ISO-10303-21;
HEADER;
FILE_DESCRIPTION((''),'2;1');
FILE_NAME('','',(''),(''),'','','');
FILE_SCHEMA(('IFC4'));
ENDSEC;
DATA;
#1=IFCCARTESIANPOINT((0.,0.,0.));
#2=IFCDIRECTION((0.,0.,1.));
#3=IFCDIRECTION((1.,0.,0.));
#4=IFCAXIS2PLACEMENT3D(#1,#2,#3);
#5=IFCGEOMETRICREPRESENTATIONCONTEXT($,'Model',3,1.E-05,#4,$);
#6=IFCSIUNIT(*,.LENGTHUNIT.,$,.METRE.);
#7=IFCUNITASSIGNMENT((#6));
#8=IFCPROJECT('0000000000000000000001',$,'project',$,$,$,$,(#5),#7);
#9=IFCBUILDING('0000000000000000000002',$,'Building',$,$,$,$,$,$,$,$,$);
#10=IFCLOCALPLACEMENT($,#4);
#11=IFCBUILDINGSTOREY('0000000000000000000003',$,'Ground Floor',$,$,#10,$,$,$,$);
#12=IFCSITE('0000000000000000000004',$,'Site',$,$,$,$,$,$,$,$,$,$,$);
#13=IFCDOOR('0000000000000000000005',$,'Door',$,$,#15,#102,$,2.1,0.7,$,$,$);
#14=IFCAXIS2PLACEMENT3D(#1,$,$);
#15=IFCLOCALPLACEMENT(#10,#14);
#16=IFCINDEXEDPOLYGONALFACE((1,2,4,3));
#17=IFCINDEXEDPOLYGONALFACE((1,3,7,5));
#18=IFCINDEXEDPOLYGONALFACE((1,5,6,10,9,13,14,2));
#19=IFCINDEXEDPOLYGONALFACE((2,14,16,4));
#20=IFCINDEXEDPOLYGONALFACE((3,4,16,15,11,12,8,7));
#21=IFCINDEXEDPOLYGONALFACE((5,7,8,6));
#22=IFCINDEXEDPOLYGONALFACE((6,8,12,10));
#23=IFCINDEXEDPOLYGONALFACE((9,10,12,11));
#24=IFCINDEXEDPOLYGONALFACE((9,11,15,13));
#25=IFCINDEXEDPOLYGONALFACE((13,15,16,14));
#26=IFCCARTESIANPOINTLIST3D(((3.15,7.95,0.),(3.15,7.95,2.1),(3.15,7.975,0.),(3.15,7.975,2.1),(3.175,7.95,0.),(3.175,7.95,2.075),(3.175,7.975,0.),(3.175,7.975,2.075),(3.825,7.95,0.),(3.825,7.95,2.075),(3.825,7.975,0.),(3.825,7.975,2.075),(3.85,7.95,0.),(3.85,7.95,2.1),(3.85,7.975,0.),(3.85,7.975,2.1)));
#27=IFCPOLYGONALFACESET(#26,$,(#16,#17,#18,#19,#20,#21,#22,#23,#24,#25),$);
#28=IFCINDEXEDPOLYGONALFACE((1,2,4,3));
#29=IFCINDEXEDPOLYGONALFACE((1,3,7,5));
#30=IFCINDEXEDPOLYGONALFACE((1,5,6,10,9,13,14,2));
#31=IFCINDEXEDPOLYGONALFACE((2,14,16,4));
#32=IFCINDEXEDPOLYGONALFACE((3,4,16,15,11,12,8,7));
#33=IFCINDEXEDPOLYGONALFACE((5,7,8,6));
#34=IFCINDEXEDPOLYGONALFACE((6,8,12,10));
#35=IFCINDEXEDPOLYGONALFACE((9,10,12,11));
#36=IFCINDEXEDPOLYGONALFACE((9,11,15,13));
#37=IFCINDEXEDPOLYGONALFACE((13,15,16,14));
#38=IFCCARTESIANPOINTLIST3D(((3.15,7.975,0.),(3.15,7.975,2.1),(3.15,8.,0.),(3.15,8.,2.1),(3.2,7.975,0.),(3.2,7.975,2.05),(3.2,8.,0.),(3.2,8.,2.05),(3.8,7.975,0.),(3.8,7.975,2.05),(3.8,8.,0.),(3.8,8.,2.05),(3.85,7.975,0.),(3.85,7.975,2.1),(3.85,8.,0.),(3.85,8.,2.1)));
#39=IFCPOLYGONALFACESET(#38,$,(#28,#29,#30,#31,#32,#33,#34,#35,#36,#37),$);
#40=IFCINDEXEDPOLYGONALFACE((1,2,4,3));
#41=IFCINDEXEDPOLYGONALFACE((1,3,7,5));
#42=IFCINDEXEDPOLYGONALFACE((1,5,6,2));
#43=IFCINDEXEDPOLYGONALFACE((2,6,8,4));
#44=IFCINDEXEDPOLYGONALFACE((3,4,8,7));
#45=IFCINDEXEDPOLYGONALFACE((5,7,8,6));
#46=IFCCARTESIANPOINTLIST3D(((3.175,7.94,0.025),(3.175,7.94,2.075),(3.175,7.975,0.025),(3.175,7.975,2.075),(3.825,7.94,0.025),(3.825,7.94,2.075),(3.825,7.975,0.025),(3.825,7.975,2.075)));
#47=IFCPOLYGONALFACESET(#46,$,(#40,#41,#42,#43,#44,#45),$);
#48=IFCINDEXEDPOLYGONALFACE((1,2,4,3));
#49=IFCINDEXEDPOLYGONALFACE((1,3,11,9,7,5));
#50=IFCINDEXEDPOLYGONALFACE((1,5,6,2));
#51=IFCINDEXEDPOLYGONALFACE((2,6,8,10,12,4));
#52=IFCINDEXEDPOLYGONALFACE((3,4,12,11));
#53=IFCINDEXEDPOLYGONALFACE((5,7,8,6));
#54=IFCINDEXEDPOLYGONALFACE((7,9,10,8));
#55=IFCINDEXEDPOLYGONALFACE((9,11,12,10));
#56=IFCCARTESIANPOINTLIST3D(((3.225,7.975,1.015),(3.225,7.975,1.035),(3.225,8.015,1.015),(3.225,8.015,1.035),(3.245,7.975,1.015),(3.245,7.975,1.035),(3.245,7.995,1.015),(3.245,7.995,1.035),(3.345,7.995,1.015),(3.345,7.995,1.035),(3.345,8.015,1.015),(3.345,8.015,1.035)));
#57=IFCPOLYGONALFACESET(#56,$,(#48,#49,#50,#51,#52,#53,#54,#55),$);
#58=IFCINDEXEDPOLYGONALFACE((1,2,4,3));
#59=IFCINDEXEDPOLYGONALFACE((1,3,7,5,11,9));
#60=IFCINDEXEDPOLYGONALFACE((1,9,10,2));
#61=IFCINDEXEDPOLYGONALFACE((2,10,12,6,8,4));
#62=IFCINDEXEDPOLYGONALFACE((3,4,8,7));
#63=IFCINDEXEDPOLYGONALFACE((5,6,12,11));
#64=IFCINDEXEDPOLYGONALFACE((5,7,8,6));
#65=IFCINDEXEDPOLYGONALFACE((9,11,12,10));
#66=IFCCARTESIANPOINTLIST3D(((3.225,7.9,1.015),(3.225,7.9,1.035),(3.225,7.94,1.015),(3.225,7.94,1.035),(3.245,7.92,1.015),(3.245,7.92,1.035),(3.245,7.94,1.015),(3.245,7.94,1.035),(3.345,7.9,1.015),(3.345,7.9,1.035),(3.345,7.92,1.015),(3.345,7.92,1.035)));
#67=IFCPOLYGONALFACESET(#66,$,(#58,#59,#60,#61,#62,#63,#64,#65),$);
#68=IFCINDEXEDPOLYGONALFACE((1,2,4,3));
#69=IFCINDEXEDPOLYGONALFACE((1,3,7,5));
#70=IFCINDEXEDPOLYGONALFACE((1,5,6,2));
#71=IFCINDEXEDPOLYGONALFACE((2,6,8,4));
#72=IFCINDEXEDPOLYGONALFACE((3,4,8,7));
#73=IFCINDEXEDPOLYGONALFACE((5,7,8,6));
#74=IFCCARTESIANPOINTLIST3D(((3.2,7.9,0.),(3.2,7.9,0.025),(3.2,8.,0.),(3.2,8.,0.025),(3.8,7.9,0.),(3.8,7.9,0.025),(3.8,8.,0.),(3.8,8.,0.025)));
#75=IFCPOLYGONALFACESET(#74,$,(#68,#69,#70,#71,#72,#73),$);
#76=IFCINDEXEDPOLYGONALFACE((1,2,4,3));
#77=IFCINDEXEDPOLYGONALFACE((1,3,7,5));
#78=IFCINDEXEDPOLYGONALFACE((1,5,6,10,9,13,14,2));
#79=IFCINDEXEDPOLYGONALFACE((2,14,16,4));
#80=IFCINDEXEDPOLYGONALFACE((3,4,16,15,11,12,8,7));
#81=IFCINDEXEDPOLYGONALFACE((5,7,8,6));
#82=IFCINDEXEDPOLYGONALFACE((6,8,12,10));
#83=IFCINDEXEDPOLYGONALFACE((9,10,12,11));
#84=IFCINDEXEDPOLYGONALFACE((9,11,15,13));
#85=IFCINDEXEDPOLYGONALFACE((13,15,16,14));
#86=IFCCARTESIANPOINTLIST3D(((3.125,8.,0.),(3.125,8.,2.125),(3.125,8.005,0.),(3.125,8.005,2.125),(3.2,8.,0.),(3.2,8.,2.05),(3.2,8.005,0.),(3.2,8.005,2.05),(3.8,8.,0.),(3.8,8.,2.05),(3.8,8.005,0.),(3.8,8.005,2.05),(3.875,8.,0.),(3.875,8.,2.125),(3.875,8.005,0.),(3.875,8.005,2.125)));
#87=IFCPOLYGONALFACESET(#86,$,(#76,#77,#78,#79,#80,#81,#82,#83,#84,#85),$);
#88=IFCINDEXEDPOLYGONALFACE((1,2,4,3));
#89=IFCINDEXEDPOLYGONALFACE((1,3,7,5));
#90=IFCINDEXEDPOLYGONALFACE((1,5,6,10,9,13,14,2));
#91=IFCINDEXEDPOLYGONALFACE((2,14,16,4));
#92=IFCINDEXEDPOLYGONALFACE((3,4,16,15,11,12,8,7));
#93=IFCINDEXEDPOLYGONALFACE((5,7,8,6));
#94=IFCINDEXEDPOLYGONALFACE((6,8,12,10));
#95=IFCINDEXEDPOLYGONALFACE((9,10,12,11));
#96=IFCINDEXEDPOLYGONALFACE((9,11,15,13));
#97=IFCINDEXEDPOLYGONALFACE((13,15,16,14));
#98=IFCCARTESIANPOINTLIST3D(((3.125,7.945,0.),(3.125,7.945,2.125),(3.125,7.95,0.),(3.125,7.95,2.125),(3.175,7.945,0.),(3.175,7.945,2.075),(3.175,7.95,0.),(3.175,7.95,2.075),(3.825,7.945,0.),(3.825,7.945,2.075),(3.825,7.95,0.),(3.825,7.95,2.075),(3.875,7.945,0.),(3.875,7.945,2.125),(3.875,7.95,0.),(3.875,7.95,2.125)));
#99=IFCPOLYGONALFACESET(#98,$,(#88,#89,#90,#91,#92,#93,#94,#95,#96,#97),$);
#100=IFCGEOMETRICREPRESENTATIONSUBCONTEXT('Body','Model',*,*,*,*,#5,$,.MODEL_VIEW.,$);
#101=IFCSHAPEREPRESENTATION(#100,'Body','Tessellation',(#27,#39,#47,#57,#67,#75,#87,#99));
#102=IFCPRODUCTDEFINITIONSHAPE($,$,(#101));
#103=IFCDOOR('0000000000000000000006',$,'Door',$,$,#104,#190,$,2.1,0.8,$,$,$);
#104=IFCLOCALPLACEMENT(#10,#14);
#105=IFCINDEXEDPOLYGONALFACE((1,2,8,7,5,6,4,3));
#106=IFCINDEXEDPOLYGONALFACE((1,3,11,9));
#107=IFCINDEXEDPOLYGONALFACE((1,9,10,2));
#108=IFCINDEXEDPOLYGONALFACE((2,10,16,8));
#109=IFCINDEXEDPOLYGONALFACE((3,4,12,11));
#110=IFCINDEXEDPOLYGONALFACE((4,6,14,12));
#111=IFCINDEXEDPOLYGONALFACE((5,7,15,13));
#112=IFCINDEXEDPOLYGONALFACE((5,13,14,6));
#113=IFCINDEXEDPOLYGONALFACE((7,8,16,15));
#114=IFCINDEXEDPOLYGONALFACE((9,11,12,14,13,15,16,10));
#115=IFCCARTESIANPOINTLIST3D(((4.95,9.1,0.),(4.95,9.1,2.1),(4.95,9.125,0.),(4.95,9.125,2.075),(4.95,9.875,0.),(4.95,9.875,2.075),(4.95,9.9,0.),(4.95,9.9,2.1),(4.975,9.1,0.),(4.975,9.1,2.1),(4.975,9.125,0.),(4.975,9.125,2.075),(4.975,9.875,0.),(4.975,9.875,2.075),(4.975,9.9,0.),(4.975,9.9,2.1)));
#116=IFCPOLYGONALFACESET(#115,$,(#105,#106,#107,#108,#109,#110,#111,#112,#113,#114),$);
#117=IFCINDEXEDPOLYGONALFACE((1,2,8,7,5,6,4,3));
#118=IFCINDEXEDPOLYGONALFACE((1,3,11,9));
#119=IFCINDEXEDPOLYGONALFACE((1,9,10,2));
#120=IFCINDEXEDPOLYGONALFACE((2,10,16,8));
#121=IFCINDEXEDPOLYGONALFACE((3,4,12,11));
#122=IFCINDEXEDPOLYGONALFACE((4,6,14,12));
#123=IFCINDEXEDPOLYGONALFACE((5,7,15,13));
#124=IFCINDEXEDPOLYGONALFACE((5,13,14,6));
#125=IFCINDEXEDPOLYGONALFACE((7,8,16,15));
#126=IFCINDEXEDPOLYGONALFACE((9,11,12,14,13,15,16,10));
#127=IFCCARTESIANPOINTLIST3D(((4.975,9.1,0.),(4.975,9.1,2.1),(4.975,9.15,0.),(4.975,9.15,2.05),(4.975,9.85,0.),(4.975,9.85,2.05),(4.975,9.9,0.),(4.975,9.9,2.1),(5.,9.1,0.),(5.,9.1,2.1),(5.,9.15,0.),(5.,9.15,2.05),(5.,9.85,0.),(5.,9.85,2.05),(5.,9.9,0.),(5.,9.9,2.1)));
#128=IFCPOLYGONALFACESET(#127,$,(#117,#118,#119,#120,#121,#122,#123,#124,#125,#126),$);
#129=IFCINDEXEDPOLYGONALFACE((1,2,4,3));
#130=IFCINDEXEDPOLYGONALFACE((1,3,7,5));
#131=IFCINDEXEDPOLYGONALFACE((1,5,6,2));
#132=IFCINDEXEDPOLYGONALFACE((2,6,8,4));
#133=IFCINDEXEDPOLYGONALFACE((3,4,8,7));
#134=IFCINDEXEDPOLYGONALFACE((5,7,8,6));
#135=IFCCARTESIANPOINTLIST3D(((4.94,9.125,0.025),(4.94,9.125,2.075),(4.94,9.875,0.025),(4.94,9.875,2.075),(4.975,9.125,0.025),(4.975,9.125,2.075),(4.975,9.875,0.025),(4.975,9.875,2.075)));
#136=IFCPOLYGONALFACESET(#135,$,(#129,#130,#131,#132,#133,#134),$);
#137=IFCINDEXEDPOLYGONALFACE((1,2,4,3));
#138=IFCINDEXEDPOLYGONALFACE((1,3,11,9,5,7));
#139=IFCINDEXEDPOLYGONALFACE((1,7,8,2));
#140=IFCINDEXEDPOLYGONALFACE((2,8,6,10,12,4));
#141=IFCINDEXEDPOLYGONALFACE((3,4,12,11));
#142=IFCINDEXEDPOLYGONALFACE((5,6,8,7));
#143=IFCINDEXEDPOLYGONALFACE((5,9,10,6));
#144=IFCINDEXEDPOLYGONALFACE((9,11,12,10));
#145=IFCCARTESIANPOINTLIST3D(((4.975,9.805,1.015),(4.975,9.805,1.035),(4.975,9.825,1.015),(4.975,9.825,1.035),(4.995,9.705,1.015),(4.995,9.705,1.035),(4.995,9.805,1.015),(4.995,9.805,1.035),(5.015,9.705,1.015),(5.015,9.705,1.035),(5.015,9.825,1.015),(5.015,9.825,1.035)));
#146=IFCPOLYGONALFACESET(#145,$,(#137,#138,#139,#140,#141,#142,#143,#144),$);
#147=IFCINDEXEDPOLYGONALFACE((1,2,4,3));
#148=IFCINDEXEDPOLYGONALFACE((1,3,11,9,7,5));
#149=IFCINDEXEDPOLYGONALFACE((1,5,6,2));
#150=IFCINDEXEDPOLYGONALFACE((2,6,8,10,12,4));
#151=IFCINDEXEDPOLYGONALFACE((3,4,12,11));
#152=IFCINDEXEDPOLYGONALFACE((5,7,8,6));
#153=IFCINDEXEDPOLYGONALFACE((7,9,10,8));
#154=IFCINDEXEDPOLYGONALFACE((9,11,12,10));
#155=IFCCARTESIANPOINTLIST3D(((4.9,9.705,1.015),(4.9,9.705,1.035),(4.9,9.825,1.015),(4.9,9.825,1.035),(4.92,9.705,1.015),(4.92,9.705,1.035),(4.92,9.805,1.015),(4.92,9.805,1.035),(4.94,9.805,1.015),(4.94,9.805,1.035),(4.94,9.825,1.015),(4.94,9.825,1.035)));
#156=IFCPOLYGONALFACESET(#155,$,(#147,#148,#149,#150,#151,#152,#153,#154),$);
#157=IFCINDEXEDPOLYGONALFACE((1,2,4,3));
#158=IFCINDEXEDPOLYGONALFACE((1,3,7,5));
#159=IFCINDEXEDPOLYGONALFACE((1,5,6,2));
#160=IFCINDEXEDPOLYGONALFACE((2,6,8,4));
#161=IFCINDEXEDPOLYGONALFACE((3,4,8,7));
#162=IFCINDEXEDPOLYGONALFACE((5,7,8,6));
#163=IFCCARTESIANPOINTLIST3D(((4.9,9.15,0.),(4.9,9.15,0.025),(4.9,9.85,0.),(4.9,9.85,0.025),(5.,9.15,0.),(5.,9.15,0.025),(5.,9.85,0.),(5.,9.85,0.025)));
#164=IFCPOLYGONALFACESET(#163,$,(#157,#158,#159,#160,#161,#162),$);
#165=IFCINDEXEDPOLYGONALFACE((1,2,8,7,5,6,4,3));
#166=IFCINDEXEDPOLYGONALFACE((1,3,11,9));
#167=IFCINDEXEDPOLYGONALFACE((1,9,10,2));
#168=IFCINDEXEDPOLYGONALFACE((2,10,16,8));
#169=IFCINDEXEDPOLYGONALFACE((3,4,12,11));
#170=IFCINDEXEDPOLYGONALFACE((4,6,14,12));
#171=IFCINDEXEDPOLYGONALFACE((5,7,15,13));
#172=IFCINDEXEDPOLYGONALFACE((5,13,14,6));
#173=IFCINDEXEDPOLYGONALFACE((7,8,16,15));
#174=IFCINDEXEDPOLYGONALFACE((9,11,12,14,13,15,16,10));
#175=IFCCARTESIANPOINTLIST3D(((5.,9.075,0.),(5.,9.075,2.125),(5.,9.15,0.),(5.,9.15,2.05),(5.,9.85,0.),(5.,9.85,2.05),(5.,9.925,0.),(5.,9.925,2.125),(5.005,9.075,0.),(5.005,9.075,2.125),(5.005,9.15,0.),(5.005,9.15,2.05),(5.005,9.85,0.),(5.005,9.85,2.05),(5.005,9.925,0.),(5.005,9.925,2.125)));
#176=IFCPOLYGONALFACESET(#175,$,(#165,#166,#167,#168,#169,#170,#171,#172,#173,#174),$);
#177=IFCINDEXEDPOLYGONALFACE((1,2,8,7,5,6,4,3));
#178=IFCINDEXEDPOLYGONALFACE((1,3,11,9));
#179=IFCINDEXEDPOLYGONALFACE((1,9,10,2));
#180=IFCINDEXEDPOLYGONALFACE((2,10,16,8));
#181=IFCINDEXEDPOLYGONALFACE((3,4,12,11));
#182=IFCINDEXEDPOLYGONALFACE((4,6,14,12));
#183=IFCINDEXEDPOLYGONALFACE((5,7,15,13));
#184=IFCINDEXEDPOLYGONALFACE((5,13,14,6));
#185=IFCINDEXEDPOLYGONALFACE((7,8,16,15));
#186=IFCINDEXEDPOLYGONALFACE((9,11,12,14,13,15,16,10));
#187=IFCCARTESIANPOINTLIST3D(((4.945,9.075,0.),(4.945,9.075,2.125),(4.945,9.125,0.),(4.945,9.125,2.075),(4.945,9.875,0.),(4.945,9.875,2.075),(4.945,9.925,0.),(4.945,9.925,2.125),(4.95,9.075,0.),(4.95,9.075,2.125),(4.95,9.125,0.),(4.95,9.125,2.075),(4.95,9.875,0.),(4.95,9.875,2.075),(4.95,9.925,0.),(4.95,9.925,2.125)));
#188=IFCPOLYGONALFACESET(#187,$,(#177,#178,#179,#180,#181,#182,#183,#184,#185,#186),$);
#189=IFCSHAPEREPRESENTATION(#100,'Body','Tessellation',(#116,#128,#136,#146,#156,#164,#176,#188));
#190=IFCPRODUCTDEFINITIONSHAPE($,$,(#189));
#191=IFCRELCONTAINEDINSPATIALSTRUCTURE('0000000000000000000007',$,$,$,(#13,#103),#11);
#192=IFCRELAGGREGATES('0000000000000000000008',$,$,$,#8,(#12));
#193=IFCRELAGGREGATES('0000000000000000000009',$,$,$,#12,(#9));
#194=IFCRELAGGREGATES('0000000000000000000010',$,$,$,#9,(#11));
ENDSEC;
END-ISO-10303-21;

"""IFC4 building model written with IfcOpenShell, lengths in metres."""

from ifc_helpers import new_model, si_unit, frame, origin_with_axes, place, context, subcontext, project, spatial, line, indexed_curve, outline, extrude, element, save


model = new_model("IFC4")

# Units and contexts
model_context = context("Model", 3, precision=1e-05, world=origin_with_axes())
body_context = subcontext(model_context, "Body", "Model", "MODEL_VIEW")
ifc_project = project(units=[si_unit("LENGTHUNIT", "METRE")], contexts=[model_context])

# Site, building, storey
site = spatial("IfcSite", under=ifc_project, Name="Site")
building = spatial("IfcBuilding", under=site, Name="Building")
storey_placement = place(None, origin_with_axes())
storey = spatial("IfcBuildingStorey", under=building, at=storey_placement, Name="Ground Floor")

# Doors
door_1_placement = place(storey_placement, frame((3.85, 8.0, 0.0), z_axis=(0.0, 0.0, 1.0), x_axis=(-1.0, 0.0, 0.0)))
element("IfcDoor", 1, at=door_1_placement, inside=storey, Name="Door", OverallHeight=2.1, OverallWidth=0.7, context=body_context, shape_type="SweptSolid", body=[
    extrude(outline(indexed_curve([(0.0, 0.0), (0.0, 2.1), (0.7, 2.1), (0.7, 0.0), (0.675, 0.0), (0.675, 2.075), (0.025, 2.075), (0.025, 0.0)], segments=[line(1, 2, 3, 4, 5, 6, 7, 8, 1)])), frame((0.0, 0.025, 0.0), z_axis=(0.0, -1.0, 0.0), x_axis=(1.0, 0.0, 0.0)), (0.0, 0.0, -1.0), 0.025),
    extrude(outline(indexed_curve([(0.0, 0.0), (0.0, 2.1), (0.7, 2.1), (0.7, 0.0), (0.65, 0.0), (0.65, 2.05), (0.05, 2.05), (0.05, 0.0)], segments=[line(1, 2, 3, 4, 5, 6, 7, 8, 1)])), frame((0.0, 0.0, 0.0), z_axis=(0.0, -1.0, 0.0), x_axis=(1.0, 0.0, 0.0)), (0.0, 0.0, -1.0), 0.025),
    extrude(outline(indexed_curve([(0.0, 0.0), (0.65, 0.0), (0.65, 0.035), (0.0, 0.035)], segments=[line(1, 2, 3, 4, 1)])), frame((0.025, 0.025, 0.025), z_axis=(0.0, 0.0, 1.0), x_axis=(1.0, 0.0, 0.0)), (0.0, 0.0, 1.0), 2.05),
    extrude(outline(indexed_curve([(0.0, 0.0), (0.0, -0.04), (-0.12, -0.04), (-0.12, -0.02), (-0.02, -0.02), (-0.02, 0.0)], segments=[line(1, 2, 3, 4, 5, 6, 1)])), frame((0.625, 0.025, 1.015), z_axis=(0.0, 0.0, 1.0), x_axis=(1.0, 0.0, 0.0)), (0.0, 0.0, 1.0), 0.02),
    extrude(outline(indexed_curve([(0.0, 0.0), (0.0, 0.04), (-0.12, 0.04), (-0.12, 0.02), (-0.02, 0.02), (-0.02, 0.0)], segments=[line(1, 2, 3, 4, 5, 6, 1)])), frame((0.625, 0.06, 1.015), z_axis=(0.0, 0.0, 1.0), x_axis=(1.0, 0.0, 0.0)), (0.0, 0.0, 1.0), 0.02),
    extrude(outline(indexed_curve([(0.0, 0.0), (0.6, 0.0), (0.6, 0.1), (0.0, 0.1)], segments=[line(1, 2, 3, 4, 1)])), frame((0.05, 0.0, 0.0), z_axis=(0.0, 0.0, 1.0), x_axis=(1.0, 0.0, 0.0)), (0.0, 0.0, 1.0), 0.025),
    extrude(outline(indexed_curve([(0.0, 0.0), (0.0, 2.125), (0.75, 2.125), (0.75, 0.0), (0.675, 0.0), (0.675, 2.05), (0.075, 2.05), (0.075, 0.0)], segments=[line(1, 2, 3, 4, 5, 6, 7, 8, 1)])), frame((-0.025, -0.005, 0.0), z_axis=(0.0, -1.0, 0.0), x_axis=(1.0, 0.0, 0.0)), (0.0, 0.0, -1.0), 0.005),
    extrude(outline(indexed_curve([(0.0, 0.0), (0.0, 2.125), (0.75, 2.125), (0.75, 0.0), (0.7, 0.0), (0.7, 2.075), (0.05, 2.075), (0.05, 0.0)], segments=[line(1, 2, 3, 4, 5, 6, 7, 8, 1)])), frame((-0.025, 0.05, 0.0), z_axis=(0.0, -1.0, 0.0), x_axis=(1.0, 0.0, 0.0)), (0.0, 0.0, -1.0), 0.005),
])
door_2_placement = place(storey_placement, frame((5.0, 9.1, 0.0), z_axis=(0.0, 0.0, 1.0), x_axis=(0.0, 1.0, 0.0)))
element("IfcDoor", 2, at=door_2_placement, inside=storey, Name="Door", OverallHeight=2.1, OverallWidth=0.8, context=body_context, shape_type="SweptSolid", body=[
    extrude(outline(indexed_curve([(0.0, 0.0), (0.0, 2.1), (0.8, 2.1), (0.8, 0.0), (0.775, 0.0), (0.775, 2.075), (0.025, 2.075), (0.025, 0.0)], segments=[line(1, 2, 3, 4, 5, 6, 7, 8, 1)])), frame((0.0, 0.025, 0.0), z_axis=(0.0, -1.0, 0.0), x_axis=(1.0, 0.0, 0.0)), (0.0, 0.0, -1.0), 0.025),
    extrude(outline(indexed_curve([(0.0, 0.0), (0.0, 2.1), (0.8, 2.1), (0.8, 0.0), (0.75, 0.0), (0.75, 2.05), (0.05, 2.05), (0.05, 0.0)], segments=[line(1, 2, 3, 4, 5, 6, 7, 8, 1)])), frame((0.0, 0.0, 0.0), z_axis=(0.0, -1.0, 0.0), x_axis=(1.0, 0.0, 0.0)), (0.0, 0.0, -1.0), 0.025),
    extrude(outline(indexed_curve([(0.0, 0.0), (0.75, 0.0), (0.75, 0.035), (0.0, 0.035)], segments=[line(1, 2, 3, 4, 1)])), frame((0.025, 0.025, 0.025), z_axis=(0.0, 0.0, 1.0), x_axis=(1.0, 0.0, 0.0)), (0.0, 0.0, 1.0), 2.05),
    extrude(outline(indexed_curve([(0.0, 0.0), (0.0, -0.04), (-0.12, -0.04), (-0.12, -0.02), (-0.02, -0.02), (-0.02, 0.0)], segments=[line(1, 2, 3, 4, 5, 6, 1)])), frame((0.725, 0.025, 1.015), z_axis=(0.0, 0.0, 1.0), x_axis=(1.0, 0.0, 0.0)), (0.0, 0.0, 1.0), 0.02),
    extrude(outline(indexed_curve([(0.0, 0.0), (0.0, 0.04), (-0.12, 0.04), (-0.12, 0.02), (-0.02, 0.02), (-0.02, 0.0)], segments=[line(1, 2, 3, 4, 5, 6, 1)])), frame((0.725, 0.06, 1.015), z_axis=(0.0, 0.0, 1.0), x_axis=(1.0, 0.0, 0.0)), (0.0, 0.0, 1.0), 0.02),
    extrude(outline(indexed_curve([(0.0, 0.0), (0.7, 0.0), (0.7, 0.1), (0.0, 0.1)], segments=[line(1, 2, 3, 4, 1)])), frame((0.05, 0.0, 0.0), z_axis=(0.0, 0.0, 1.0), x_axis=(1.0, 0.0, 0.0)), (0.0, 0.0, 1.0), 0.025),
    extrude(outline(indexed_curve([(0.0, 0.0), (0.0, 2.125), (0.85, 2.125), (0.85, 0.0), (0.775, 0.0), (0.775, 2.05), (0.075, 2.05), (0.075, 0.0)], segments=[line(1, 2, 3, 4, 5, 6, 7, 8, 1)])), frame((-0.025, -0.005, 0.0), z_axis=(0.0, -1.0, 0.0), x_axis=(1.0, 0.0, 0.0)), (0.0, 0.0, -1.0), 0.005),
    extrude(outline(indexed_curve([(0.0, 0.0), (0.0, 2.125), (0.85, 2.125), (0.85, 0.0), (0.8, 0.0), (0.8, 2.075), (0.05, 2.075), (0.05, 0.0)], segments=[line(1, 2, 3, 4, 5, 6, 7, 8, 1)])), frame((-0.025, 0.05, 0.0), z_axis=(0.0, -1.0, 0.0), x_axis=(1.0, 0.0, 0.0)), (0.0, 0.0, -1.0), 0.005),
])

save(model, "model.ifc")
